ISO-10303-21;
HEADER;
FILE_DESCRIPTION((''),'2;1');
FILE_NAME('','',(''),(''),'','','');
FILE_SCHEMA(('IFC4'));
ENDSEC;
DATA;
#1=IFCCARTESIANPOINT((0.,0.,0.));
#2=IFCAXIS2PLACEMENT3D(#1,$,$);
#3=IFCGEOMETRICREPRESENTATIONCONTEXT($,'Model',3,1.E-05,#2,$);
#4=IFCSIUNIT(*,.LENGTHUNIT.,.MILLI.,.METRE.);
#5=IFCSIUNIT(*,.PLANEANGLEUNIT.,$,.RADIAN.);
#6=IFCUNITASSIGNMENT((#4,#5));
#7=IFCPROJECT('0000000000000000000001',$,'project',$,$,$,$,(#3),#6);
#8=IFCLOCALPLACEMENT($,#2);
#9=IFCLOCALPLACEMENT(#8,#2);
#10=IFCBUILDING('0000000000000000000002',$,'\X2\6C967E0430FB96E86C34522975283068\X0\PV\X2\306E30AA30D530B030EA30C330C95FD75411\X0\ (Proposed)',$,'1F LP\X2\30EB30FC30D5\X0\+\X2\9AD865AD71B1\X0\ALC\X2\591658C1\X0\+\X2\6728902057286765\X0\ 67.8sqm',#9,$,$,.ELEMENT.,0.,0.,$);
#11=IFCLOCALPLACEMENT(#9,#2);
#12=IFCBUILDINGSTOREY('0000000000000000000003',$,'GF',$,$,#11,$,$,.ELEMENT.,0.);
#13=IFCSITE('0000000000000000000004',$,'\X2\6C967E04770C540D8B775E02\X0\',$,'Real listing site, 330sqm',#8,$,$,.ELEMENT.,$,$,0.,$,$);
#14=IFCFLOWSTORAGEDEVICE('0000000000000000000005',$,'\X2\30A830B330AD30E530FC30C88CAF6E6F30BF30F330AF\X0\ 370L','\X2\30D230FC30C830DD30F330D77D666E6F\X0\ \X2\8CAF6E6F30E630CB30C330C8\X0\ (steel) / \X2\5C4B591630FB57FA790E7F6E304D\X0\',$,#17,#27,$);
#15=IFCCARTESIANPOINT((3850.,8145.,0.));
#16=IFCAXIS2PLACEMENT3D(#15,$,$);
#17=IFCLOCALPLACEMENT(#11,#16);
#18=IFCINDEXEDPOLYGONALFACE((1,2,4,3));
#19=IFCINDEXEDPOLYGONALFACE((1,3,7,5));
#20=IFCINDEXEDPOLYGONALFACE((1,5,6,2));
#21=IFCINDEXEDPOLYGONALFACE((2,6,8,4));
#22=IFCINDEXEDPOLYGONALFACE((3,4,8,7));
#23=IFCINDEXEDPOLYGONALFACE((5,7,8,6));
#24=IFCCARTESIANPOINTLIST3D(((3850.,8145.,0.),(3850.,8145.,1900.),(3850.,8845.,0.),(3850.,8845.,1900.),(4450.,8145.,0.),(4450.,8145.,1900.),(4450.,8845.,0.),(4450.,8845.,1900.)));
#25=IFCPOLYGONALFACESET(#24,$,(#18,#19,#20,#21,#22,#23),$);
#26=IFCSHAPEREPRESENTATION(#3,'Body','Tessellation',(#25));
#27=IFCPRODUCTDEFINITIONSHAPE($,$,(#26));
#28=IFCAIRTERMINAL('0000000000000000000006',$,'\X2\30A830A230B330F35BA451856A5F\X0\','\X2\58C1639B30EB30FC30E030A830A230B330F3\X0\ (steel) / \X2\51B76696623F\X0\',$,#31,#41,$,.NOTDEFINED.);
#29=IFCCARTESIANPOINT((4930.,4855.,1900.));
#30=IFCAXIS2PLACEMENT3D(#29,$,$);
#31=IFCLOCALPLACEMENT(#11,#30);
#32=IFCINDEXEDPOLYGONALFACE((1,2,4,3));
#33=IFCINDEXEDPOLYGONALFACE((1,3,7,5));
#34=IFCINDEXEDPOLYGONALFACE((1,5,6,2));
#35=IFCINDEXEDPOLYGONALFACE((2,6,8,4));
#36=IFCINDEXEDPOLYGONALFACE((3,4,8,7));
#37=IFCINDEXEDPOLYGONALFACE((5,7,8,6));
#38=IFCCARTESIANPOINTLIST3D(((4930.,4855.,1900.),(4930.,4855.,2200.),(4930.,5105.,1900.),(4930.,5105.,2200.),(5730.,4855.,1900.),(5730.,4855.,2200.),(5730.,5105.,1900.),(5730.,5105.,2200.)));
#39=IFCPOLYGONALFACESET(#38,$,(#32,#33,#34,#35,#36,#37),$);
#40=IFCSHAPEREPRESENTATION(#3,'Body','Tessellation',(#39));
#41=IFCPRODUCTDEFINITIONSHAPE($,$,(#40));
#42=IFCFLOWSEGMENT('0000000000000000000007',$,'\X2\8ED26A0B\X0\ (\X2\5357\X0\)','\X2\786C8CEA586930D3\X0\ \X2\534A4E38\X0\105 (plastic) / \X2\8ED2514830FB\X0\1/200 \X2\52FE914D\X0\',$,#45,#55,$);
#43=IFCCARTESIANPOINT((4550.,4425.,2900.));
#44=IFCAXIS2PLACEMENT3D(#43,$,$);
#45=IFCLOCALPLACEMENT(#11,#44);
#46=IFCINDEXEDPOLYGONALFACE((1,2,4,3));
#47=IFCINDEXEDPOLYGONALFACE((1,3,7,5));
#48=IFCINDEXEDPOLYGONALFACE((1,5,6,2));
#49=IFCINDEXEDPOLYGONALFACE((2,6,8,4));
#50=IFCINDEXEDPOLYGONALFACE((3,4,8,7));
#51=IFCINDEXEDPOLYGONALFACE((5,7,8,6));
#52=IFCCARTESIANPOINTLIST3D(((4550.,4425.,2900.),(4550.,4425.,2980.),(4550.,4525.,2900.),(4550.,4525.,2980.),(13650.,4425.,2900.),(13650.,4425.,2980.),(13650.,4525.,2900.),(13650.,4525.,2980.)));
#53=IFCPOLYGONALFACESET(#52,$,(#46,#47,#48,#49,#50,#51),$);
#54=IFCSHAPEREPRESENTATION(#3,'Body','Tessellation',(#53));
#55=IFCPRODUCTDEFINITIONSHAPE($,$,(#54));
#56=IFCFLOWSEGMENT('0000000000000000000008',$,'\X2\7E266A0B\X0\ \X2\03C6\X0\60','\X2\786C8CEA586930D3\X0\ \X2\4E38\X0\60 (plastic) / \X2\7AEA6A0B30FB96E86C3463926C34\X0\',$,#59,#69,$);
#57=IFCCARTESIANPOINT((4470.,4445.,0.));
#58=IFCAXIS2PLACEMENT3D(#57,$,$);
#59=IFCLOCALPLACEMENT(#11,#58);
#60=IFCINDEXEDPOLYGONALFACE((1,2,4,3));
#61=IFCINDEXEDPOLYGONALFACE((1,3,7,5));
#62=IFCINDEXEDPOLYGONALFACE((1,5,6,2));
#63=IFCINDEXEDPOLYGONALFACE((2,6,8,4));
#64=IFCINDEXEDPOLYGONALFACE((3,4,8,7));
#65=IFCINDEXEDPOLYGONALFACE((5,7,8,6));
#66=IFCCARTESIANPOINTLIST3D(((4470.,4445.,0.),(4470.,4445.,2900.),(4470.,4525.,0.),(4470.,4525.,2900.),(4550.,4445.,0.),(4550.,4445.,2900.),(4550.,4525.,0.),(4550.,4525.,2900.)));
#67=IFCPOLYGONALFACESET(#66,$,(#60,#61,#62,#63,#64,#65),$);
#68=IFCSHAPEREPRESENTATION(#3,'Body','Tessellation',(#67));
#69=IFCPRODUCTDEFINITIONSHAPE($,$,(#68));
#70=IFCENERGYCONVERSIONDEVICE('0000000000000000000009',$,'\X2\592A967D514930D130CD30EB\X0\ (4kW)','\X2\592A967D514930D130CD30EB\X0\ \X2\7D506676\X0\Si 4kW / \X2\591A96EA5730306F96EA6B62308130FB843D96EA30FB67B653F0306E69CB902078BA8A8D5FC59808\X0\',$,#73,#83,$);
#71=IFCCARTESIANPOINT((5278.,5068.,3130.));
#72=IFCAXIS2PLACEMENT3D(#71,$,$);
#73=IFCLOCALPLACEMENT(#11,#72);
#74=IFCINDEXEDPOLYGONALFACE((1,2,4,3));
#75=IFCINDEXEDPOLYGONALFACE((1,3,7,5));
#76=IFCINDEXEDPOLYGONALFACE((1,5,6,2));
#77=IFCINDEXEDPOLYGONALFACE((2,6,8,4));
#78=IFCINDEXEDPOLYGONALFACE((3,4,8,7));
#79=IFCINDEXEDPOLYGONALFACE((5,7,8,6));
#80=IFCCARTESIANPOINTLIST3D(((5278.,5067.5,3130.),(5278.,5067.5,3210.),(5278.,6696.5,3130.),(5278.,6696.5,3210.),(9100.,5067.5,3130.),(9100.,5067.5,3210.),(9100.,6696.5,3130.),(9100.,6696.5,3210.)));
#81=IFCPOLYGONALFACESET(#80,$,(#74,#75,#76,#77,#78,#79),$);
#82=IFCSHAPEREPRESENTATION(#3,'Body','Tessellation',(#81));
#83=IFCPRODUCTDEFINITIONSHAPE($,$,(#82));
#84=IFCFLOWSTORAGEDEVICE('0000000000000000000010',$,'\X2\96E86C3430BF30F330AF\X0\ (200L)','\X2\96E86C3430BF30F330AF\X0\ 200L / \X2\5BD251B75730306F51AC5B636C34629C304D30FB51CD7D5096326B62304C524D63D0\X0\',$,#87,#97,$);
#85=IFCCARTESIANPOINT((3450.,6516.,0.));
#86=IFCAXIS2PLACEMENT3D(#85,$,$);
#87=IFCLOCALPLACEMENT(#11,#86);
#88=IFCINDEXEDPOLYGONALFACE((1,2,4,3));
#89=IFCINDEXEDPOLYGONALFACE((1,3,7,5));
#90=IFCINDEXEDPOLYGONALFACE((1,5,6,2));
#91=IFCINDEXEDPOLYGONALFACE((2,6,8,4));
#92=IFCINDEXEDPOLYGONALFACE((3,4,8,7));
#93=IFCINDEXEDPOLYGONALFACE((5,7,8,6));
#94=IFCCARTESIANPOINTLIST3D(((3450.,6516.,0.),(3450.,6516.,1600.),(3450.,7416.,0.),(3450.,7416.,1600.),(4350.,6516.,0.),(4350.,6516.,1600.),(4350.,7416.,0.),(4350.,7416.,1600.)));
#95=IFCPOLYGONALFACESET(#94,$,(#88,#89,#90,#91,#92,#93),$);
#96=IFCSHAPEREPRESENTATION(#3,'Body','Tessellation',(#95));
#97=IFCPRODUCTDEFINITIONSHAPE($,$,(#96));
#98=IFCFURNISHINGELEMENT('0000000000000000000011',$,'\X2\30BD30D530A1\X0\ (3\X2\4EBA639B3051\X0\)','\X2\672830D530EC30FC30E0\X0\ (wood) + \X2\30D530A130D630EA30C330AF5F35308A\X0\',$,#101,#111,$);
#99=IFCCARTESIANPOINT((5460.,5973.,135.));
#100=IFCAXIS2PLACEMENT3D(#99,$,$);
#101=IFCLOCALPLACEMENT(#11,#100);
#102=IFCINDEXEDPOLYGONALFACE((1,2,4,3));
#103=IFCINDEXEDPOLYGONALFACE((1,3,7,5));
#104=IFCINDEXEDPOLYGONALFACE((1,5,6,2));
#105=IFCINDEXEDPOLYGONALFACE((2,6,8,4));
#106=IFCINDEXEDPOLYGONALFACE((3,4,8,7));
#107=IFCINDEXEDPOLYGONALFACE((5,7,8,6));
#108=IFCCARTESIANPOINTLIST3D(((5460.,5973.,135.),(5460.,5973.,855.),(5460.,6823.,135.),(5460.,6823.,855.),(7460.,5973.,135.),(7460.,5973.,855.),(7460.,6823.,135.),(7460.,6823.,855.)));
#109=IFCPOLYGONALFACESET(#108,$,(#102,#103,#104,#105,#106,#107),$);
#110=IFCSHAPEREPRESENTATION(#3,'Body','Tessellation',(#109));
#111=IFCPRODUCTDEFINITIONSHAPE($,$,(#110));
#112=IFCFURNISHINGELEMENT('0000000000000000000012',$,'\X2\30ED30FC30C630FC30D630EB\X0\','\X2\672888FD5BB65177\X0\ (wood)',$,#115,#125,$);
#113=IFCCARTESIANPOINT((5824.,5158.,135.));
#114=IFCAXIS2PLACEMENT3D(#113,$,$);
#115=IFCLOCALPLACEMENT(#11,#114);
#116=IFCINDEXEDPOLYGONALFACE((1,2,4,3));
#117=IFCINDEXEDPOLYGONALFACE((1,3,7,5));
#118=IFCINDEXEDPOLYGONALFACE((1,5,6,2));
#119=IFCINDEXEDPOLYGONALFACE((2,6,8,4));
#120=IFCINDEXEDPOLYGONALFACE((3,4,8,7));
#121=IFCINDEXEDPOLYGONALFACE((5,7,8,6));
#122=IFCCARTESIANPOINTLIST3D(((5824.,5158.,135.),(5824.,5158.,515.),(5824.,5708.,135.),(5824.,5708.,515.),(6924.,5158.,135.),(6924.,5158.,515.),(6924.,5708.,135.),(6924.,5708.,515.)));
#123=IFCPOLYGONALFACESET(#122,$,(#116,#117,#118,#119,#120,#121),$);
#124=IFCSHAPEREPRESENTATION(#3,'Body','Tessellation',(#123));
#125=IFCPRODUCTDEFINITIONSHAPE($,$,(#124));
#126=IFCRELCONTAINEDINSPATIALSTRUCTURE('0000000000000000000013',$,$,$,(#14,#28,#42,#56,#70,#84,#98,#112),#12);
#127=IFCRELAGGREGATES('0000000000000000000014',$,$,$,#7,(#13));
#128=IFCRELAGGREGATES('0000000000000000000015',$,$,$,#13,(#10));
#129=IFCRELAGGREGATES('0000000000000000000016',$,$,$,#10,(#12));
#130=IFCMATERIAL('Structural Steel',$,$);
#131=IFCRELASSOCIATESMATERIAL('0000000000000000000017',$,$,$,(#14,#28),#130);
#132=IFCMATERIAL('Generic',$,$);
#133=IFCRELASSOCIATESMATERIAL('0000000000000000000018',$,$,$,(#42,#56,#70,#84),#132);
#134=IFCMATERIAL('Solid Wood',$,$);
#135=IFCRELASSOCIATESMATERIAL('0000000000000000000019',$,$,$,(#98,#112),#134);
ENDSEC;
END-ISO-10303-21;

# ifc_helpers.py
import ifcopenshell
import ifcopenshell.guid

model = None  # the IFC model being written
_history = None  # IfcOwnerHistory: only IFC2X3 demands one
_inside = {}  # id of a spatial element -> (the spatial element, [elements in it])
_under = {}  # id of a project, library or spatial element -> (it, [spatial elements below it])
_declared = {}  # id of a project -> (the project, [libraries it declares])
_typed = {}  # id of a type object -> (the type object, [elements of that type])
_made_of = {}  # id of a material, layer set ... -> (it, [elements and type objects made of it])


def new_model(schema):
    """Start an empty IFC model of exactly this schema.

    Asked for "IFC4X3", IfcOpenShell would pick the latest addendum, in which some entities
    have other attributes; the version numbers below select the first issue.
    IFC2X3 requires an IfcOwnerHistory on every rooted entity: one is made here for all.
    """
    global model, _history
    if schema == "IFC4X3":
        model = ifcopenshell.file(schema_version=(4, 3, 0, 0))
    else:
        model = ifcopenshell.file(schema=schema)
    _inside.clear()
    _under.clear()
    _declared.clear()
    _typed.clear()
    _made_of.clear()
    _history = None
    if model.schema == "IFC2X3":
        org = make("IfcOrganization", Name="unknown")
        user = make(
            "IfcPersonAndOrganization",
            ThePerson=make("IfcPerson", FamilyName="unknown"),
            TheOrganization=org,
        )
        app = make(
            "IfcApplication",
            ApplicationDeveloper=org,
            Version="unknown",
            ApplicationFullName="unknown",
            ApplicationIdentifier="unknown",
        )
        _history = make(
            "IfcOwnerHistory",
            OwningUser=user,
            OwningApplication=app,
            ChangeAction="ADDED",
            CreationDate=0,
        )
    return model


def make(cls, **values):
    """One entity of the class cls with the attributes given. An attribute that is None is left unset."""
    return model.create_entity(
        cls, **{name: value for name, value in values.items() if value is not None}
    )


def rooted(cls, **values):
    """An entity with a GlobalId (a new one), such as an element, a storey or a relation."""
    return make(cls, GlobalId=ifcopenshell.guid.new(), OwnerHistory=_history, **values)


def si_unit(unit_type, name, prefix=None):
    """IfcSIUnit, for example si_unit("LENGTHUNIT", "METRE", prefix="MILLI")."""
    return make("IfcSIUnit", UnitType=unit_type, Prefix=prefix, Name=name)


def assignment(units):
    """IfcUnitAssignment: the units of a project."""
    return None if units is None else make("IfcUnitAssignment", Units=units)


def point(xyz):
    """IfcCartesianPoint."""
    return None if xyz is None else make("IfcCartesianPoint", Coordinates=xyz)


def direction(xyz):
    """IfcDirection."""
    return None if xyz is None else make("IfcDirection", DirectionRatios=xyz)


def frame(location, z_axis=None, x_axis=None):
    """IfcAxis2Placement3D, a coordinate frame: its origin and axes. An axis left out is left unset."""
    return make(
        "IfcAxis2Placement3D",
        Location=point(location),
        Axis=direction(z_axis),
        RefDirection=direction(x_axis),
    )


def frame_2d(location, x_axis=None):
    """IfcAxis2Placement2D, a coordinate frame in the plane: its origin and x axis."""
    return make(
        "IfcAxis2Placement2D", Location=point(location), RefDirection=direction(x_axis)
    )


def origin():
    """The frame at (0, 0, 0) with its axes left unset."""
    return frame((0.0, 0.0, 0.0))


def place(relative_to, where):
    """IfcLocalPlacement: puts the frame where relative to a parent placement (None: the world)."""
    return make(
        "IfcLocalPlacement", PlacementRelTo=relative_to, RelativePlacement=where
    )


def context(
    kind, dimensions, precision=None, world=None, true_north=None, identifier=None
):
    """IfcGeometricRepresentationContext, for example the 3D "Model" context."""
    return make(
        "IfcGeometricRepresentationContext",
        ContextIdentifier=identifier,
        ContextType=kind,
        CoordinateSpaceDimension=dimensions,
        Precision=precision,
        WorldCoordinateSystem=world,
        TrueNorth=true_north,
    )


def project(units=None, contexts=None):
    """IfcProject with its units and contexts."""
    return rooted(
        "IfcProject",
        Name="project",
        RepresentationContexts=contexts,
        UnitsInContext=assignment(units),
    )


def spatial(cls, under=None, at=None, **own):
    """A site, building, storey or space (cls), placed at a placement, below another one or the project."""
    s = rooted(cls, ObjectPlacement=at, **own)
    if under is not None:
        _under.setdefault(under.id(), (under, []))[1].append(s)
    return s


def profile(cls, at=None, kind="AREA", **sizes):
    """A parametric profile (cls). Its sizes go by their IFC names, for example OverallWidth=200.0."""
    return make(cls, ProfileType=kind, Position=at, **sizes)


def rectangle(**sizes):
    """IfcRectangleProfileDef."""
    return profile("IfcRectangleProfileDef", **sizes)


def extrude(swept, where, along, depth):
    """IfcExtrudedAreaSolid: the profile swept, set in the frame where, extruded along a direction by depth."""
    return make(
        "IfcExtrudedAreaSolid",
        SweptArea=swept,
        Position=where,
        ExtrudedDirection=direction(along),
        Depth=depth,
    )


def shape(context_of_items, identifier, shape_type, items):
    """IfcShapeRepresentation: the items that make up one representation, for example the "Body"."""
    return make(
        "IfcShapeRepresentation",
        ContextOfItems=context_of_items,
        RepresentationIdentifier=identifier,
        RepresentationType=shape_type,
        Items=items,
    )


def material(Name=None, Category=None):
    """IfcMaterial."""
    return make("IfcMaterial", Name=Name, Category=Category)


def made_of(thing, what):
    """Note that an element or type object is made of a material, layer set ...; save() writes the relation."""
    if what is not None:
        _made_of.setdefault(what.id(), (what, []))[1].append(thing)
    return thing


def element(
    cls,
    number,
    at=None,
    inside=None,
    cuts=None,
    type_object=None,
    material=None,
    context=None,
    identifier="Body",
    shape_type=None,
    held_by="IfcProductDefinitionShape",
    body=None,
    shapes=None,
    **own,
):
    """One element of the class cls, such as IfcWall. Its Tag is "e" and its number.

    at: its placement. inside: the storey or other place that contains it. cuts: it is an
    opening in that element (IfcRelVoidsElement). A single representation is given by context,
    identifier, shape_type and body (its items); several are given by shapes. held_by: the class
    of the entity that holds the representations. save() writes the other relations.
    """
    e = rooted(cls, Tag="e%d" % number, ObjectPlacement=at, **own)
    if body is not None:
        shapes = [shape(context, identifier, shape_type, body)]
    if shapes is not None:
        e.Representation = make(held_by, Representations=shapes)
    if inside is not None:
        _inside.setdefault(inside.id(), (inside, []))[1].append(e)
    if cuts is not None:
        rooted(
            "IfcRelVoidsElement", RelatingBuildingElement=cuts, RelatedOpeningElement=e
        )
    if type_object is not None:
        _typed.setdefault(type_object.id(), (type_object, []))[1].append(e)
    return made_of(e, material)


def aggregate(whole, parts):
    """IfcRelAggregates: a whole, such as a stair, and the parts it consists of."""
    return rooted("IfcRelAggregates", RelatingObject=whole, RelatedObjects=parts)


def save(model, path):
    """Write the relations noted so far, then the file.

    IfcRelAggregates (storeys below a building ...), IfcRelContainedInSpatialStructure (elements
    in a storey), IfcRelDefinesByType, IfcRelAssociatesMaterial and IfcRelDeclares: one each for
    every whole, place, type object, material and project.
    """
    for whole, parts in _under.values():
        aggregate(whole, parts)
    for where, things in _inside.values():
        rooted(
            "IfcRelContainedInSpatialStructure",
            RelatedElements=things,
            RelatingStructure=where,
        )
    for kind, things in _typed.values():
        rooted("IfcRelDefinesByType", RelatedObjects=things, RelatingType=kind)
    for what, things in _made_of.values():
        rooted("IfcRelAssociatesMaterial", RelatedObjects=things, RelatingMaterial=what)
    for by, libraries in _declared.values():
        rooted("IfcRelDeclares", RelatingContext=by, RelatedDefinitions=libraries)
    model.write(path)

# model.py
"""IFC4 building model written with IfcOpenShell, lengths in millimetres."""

from ifc_helpers import new_model, si_unit, frame, frame_2d, origin, place, context, project, spatial, rectangle, extrude, material, element, save


model = new_model("IFC4")

# Units and contexts
model_context = context("Model", 3, precision=1e-05, world=origin())
ifc_project = project(units=[si_unit("LENGTHUNIT", "METRE", prefix="MILLI"), si_unit("PLANEANGLEUNIT", "RADIAN")], contexts=[model_context])

# Site, building, storey
site_placement = place(None, origin())
site = spatial("IfcSite", under=ifc_project, at=site_placement, Name="沖縄県名護市", ObjectType="Real listing site, 330sqm", CompositionType="ELEMENT", RefElevation=0.0)
building_placement = place(site_placement, origin())
building = spatial("IfcBuilding", under=site, at=building_placement, Name="沖縄・雨水利用とPVのオフグリッド志向 (Proposed)", ObjectType="1F LPルーフ+高断熱ALC外壁+木造在来 67.8sqm", CompositionType="ELEMENT", ElevationOfRefHeight=0.0, ElevationOfTerrain=0.0)
storey_placement = place(building_placement, origin())
storey = spatial("IfcBuildingStorey", under=building, at=storey_placement, Name="GF", CompositionType="ELEMENT", Elevation=0.0)

# Shared definitions
ifc_material_1 = material(Name="Solid Wood")

# Shared definitions
ifc_material_2 = material(Name="Structural Steel")

# Shared definitions
ifc_material_3 = material(Name="Generic")

# Flow storage device
flow_storage_device_1_placement = place(storey_placement, frame((3850.0, 8145.0, 0.0)))
element("IfcFlowStorageDevice", 1, at=flow_storage_device_1_placement, inside=storey, material=ifc_material_2, Name="エコキュート貯湯タンク 370L", Description="ヒートポンプ給湯 貯湯ユニット (steel) / 屋外・基礎置き", context=model_context, shape_type="SweptSolid", body=[
    extrude(rectangle(XDim=600.0, YDim=700.0, at=frame_2d((300.0, 350.0))), frame((3850.0, 8145.0, 0.0)), (0.0, 0.0, 1.0), 1900.0),
])

# Air terminal
air_terminal_placement = place(storey_placement, frame((4930.0, 4855.0, 1900.0)))
element("IfcAirTerminal", 2, at=air_terminal_placement, inside=storey, material=ifc_material_2, Name="エアコン室内機", Description="壁掛ルームエアコン (steel) / 冷暖房", PredefinedType="NOTDEFINED", context=model_context, shape_type="SweptSolid", body=[
    extrude(rectangle(XDim=800.0, YDim=250.0, at=frame_2d((400.0, 125.0))), frame((4930.0, 4855.0, 1900.0)), (0.0, 0.0, 1.0), 300.0),
])

# Flow segments
flow_segment_1_placement = place(storey_placement, frame((4550.0, 4425.0, 2900.0)))
element("IfcFlowSegment", 3, at=flow_segment_1_placement, inside=storey, material=ifc_material_3, Name="軒樋 (南)", Description="硬質塩ビ 半丸105 (plastic) / 軒先・1/200 勾配", context=model_context, shape_type="SweptSolid", body=[
    extrude(rectangle(XDim=9100.0, YDim=100.0, at=frame_2d((4550.0, 50.0))), frame((4550.0, 4425.0, 2900.0)), (0.0, 0.0, 1.0), 80.0),
])
flow_segment_2_placement = place(storey_placement, frame((4470.0, 4445.0, 0.0)))
element("IfcFlowSegment", 4, at=flow_segment_2_placement, inside=storey, material=ifc_material_3, Name="縦樋 φ60", Description="硬質塩ビ 丸60 (plastic) / 竪樋・雨水排水", context=model_context, shape_type="SweptSolid", body=[
    extrude(rectangle(XDim=80.0, YDim=80.0, at=frame_2d((40.0, 40.0))), frame((4470.0, 4445.0, 0.0)), (0.0, 0.0, 1.0), 2900.0),
])

# Energy conversion device
energy_conversion_device_placement = place(storey_placement, frame((5278.0, 5068.0, 3130.0)))
element("IfcEnergyConversionDevice", 5, at=energy_conversion_device_placement, inside=storey, material=ifc_material_3, Name="太陽光パネル (4kW)", Description="太陽光パネル 結晶Si 4kW / 多雪地は雪止め・落雪・架台の構造確認必須", context=model_context, shape_type="SweptSolid", body=[
    extrude(rectangle(XDim=3822.0, YDim=1629.0, at=frame_2d((1911.0, 814.0))), frame((5278.0, 5068.0, 3130.0)), (0.0, 0.0, 1.0), 80.0),
])

# Flow storage device
flow_storage_device_2_placement = place(storey_placement, frame((3450.0, 6516.0, 0.0)))
element("IfcFlowStorageDevice", 6, at=flow_storage_device_2_placement, inside=storey, material=ifc_material_3, Name="雨水タンク (200L)", Description="雨水タンク 200L / 寒冷地は冬季水抜き・凍結防止が前提", context=model_context, shape_type="SweptSolid", body=[
    extrude(rectangle(XDim=900.0, YDim=900.0, at=frame_2d((450.0, 450.0))), frame((3450.0, 6516.0, 0.0)), (0.0, 0.0, 1.0), 1600.0),
])

# Furnishing elements
furnishing_1_placement = place(storey_placement, frame((5460.0, 5973.0, 135.0)))
element("IfcFurnishingElement", 7, at=furnishing_1_placement, inside=storey, material=ifc_material_1, Name="ソファ (3人掛け)", Description="木フレーム (wood) + ファブリック張り", context=model_context, shape_type="SweptSolid", body=[
    extrude(rectangle(XDim=2000.0, YDim=850.0, at=frame_2d((1000.0, 425.0))), frame((5460.0, 5973.0, 135.0)), (0.0, 0.0, 1.0), 720.0),
])
furnishing_2_placement = place(storey_placement, frame((5824.0, 5158.0, 135.0)))
element("IfcFurnishingElement", 8, at=furnishing_2_placement, inside=storey, material=ifc_material_1, Name="ローテーブル", Description="木製家具 (wood)", context=model_context, shape_type="SweptSolid", body=[
    extrude(rectangle(XDim=1100.0, YDim=550.0, at=frame_2d((550.0, 275.0))), frame((5824.0, 5158.0, 135.0)), (0.0, 0.0, 1.0), 380.0),
])

save(model, "model.ifc")
